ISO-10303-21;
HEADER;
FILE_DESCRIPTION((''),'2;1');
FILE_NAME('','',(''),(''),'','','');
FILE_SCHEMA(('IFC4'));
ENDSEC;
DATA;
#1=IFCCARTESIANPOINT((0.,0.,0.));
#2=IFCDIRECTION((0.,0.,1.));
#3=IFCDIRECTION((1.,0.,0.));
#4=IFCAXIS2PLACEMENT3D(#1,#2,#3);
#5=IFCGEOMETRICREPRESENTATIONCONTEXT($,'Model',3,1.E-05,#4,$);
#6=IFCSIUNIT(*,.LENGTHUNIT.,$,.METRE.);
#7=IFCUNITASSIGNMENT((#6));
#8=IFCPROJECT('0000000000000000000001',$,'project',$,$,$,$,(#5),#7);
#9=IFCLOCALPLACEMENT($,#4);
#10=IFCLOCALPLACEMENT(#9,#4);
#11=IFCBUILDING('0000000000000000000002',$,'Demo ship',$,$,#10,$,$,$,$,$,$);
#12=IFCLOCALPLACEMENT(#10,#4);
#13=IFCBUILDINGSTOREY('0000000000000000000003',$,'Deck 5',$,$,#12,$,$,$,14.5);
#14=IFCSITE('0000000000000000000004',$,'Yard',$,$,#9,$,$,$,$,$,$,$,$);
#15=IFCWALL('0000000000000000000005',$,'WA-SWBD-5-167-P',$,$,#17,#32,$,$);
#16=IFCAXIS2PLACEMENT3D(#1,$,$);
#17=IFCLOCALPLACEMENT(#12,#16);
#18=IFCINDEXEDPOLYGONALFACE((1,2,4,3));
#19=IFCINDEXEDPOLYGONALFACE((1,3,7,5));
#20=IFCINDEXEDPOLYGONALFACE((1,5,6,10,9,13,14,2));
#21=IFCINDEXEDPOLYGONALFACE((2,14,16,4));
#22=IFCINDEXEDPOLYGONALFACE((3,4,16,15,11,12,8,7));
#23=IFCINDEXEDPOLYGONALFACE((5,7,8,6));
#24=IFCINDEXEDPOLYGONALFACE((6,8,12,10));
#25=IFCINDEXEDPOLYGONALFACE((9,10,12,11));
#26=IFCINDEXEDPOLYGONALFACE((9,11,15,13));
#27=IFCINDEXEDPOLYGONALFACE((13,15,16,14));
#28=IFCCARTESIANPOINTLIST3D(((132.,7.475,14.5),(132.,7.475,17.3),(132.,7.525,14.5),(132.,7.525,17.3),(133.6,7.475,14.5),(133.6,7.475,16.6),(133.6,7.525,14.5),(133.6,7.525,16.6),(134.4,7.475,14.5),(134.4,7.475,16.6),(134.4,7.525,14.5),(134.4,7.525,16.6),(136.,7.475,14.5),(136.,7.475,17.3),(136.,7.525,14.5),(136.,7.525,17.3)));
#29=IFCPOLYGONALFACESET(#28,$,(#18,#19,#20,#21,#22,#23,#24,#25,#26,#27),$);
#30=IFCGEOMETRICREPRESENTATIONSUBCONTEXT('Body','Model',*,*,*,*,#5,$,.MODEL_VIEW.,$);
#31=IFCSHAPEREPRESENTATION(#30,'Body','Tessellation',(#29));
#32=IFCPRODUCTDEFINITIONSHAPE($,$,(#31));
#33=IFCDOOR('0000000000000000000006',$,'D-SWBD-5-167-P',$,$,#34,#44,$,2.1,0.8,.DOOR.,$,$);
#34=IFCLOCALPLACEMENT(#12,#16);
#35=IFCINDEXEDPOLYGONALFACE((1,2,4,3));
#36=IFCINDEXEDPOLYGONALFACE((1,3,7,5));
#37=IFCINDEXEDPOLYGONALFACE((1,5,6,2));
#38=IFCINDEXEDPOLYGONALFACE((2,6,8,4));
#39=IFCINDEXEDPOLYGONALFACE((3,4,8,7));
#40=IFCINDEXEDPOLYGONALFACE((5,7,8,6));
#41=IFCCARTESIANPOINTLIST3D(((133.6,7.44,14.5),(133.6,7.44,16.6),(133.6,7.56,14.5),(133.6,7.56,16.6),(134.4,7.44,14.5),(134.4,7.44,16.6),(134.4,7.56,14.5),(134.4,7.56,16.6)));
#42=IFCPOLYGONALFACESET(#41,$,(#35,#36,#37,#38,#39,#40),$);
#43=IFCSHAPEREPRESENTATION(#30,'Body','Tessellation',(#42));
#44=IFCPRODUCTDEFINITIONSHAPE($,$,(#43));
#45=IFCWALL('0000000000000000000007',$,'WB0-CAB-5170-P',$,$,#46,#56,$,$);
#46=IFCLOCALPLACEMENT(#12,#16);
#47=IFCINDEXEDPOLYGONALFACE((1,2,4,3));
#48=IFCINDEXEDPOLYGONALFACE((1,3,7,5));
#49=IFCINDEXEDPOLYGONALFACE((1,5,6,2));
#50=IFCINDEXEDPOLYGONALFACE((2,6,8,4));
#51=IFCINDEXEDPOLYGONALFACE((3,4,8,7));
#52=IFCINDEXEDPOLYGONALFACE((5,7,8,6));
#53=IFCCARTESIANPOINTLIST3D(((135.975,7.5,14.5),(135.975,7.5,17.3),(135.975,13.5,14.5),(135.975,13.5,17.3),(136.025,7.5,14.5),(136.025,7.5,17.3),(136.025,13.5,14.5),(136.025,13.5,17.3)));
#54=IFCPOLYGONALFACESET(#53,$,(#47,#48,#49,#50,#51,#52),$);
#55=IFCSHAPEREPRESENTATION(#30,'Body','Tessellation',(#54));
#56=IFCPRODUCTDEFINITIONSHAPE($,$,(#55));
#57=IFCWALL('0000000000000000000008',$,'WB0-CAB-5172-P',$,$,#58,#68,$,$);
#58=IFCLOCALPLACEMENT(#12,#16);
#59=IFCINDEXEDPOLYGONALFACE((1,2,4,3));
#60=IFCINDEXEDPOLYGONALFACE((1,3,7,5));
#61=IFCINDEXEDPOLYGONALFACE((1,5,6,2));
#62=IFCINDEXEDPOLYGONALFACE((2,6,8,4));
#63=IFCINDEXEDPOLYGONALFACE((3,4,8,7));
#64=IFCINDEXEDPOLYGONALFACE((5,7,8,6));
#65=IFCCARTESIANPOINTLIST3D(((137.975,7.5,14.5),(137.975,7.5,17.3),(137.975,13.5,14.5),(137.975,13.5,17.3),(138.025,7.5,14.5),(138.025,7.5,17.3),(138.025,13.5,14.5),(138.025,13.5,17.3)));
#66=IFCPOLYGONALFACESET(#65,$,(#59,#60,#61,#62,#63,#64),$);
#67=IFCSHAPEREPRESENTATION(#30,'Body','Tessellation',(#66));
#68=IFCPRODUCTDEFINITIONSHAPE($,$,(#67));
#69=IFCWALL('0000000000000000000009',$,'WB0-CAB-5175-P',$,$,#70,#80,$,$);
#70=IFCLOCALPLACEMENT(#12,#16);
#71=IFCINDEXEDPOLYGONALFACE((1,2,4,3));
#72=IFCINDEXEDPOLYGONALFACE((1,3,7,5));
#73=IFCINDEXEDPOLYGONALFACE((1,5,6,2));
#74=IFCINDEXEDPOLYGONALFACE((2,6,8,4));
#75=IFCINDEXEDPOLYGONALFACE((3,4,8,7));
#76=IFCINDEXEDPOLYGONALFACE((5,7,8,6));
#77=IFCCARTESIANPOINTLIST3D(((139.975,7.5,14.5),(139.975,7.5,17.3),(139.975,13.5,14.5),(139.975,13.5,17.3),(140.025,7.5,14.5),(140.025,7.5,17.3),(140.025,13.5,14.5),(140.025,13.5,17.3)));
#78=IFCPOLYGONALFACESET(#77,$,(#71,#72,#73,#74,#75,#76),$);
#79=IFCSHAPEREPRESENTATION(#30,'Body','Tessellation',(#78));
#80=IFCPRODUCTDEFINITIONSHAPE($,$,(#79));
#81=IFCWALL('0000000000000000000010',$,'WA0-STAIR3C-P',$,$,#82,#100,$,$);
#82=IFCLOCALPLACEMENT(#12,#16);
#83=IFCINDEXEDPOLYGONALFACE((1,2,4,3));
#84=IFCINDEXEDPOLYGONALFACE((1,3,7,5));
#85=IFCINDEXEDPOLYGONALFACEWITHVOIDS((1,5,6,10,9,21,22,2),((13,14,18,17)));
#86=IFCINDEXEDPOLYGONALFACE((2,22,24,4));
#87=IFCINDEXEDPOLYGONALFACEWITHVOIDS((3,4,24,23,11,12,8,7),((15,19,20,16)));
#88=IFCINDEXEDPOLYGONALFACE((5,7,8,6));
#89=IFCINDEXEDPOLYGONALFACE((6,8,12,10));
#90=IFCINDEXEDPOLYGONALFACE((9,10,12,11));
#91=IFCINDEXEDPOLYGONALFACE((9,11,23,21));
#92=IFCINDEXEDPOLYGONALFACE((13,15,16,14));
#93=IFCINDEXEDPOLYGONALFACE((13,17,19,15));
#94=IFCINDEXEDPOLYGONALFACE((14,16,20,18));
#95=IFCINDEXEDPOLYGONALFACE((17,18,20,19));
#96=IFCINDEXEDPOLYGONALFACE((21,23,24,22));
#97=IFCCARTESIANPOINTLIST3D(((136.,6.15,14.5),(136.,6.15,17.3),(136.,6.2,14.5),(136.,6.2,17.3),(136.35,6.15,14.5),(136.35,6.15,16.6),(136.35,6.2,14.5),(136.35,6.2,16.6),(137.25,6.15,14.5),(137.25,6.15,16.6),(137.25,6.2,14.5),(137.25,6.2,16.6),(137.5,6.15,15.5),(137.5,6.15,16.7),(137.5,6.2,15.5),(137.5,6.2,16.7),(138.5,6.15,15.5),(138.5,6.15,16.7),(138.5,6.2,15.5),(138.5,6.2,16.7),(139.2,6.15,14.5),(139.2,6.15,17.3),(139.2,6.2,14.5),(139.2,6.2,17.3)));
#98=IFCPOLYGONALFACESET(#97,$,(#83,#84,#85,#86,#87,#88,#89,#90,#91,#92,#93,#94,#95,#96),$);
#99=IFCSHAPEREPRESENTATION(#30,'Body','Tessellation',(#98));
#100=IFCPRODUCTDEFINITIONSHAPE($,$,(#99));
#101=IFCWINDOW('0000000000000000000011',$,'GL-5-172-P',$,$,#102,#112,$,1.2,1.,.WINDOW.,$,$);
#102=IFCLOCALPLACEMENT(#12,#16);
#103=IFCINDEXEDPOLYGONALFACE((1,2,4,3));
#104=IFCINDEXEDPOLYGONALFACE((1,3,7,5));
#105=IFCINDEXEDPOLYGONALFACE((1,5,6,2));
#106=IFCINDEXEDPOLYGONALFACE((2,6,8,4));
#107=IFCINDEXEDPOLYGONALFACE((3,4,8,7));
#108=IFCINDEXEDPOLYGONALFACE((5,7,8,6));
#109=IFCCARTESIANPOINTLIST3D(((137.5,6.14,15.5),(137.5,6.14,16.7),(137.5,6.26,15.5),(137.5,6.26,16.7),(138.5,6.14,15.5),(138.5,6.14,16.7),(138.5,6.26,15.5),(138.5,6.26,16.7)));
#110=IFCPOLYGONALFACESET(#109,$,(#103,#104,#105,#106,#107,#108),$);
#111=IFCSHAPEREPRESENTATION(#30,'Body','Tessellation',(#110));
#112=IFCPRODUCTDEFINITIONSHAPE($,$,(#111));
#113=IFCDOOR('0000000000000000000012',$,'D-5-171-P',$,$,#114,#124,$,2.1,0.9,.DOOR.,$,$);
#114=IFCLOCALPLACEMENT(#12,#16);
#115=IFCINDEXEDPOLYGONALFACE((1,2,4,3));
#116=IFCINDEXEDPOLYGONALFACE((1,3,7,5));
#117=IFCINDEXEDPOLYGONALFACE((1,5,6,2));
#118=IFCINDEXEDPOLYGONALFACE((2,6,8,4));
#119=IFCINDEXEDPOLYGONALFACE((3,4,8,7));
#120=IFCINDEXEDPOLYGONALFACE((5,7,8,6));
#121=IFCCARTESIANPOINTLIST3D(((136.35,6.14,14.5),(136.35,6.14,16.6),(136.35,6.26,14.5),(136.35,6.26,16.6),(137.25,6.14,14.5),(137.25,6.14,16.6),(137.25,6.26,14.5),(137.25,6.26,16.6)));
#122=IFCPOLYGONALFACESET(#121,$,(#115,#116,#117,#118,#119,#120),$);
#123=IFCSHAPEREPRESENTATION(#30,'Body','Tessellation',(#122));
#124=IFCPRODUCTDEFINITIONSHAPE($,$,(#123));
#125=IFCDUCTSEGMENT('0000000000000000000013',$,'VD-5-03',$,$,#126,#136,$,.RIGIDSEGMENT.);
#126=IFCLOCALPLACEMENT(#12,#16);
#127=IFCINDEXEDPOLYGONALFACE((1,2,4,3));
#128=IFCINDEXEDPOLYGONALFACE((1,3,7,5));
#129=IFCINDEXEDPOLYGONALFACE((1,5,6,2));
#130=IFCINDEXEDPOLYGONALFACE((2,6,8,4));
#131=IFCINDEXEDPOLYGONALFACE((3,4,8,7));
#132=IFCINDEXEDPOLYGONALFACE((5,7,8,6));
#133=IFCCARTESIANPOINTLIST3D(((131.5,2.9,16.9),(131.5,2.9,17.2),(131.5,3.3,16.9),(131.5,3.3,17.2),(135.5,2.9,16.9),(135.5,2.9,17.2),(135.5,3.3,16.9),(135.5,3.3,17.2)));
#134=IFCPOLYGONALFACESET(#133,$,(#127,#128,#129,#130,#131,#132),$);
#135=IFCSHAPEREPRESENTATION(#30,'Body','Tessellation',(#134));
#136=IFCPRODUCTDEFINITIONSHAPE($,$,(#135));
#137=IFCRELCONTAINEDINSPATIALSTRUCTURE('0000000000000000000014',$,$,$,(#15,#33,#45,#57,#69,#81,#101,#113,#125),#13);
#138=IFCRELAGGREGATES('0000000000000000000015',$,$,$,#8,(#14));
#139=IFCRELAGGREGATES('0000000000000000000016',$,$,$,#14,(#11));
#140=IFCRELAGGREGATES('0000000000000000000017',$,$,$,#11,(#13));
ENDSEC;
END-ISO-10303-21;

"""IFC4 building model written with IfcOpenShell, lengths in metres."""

from ifc_helpers import new_model, si_unit, frame, frame_2d, origin, origin_with_axes, place, context, subcontext, project, spatial, rectangle, extrude, element, fill, save


model = new_model("IFC4")

# Units and contexts
model_context = context("Model", 3, precision=1e-05, world=origin_with_axes())
body_context = subcontext(model_context, "Body", "Model", "MODEL_VIEW")
ifc_project = project(units=[si_unit("LENGTHUNIT", "METRE")], contexts=[model_context])

# Site, building, storey
site_placement = place(None, origin_with_axes())
site = spatial("IfcSite", under=ifc_project, at=site_placement, Name="Yard")
building_placement = place(site_placement, origin_with_axes())
building = spatial("IfcBuilding", under=site, at=building_placement, Name="Demo ship")
storey_placement = place(building_placement, origin_with_axes())
storey = spatial("IfcBuildingStorey", under=building, at=storey_placement, Name="Deck 5", Elevation=14.5)

# Wall, opening, door
wall_1_placement = place(storey_placement, frame((132.0, 7.475, 14.5), z_axis=(0.0, 0.0, 1.0), x_axis=(1.0, 0.0, 0.0)))
wall_1 = element("IfcWall", 1, at=wall_1_placement, inside=storey, Name="WA-SWBD-5-167-P", context=body_context, shape_type="SweptSolid", body=[
    extrude(rectangle(XDim=4.0, YDim=0.05, at=frame_2d((2.0, 0.025))), origin(), (0.0, 0.0, 1.0), 2.8),
])
opening_1_placement = place(None, frame((133.6, 7.44, 14.5), z_axis=(0.0, 0.0, 1.0), x_axis=(1.0, 0.0, 0.0)))
opening_1 = element("IfcOpeningElement", 2, at=opening_1_placement, cuts=wall_1, context=body_context, shape_type="SweptSolid", body=[
    extrude(rectangle(XDim=0.8, YDim=0.12, at=frame_2d((0.4, 0.06))), origin(), (0.0, 0.0, 1.0), 2.1),
])
door_1_placement = place(storey_placement, frame((133.6, 7.44, 14.5), z_axis=(0.0, 0.0, 1.0), x_axis=(1.0, 0.0, 0.0)))
door_1 = element("IfcDoor", 3, at=door_1_placement, inside=storey, Name="D-SWBD-5-167-P", OverallHeight=2.1, OverallWidth=0.8, PredefinedType="DOOR", context=body_context, shape_type="SweptSolid", body=[
    extrude(rectangle(XDim=0.8, YDim=0.12, at=frame_2d((0.4, 0.06))), origin(), (0.0, 0.0, 1.0), 2.1),
])
fill(opening_1, door_1)

# Walls
for number, where, z_axis, x_axis, name in (
    (4, (135.975, 7.5, 14.5), (0.0, 0.0, 1.0), (1.0, 0.0, 0.0), "WB0-CAB-5170-P"),
    (5, (137.975, 7.5, 14.5), (0.0, 0.0, 1.0), (1.0, 0.0, 0.0), "WB0-CAB-5172-P"),
    (6, (139.975, 7.5, 14.5), (0.0, 0.0, 1.0), (1.0, 0.0, 0.0), "WB0-CAB-5175-P"),
):
    element("IfcWall", number, at=place(storey_placement, frame(where, z_axis=z_axis, x_axis=x_axis)), inside=storey, Name=name, context=body_context, shape_type="SweptSolid", body=[
        extrude(rectangle(XDim=0.05, YDim=6.0, at=frame_2d((0.025, 3.0))), origin(), (0.0, 0.0, 1.0), 2.8),
    ])

# Wall, openings, window, door
wall_2_placement = place(storey_placement, frame((136.0, 6.15, 14.5), z_axis=(0.0, 0.0, 1.0), x_axis=(1.0, 0.0, 0.0)))
wall_2 = element("IfcWall", 7, at=wall_2_placement, inside=storey, Name="WA0-STAIR3C-P", context=body_context, shape_type="SweptSolid", body=[
    extrude(rectangle(XDim=3.2, YDim=0.05, at=frame_2d((1.6, 0.025))), origin(), (0.0, 0.0, 1.0), 2.8),
])
opening_2_placement = place(None, frame((137.5, 6.14, 15.5), z_axis=(0.0, 0.0, 1.0), x_axis=(1.0, 0.0, 0.0)))
opening_2 = element("IfcOpeningElement", 8, at=opening_2_placement, cuts=wall_2, context=body_context, shape_type="SweptSolid", body=[
    extrude(rectangle(XDim=1.0, YDim=0.12, at=frame_2d((0.5, 0.06))), origin(), (0.0, 0.0, 1.0), 1.2),
])
opening_3_placement = place(None, frame((136.35, 6.14, 14.5), z_axis=(0.0, 0.0, 1.0), x_axis=(1.0, 0.0, 0.0)))
opening_3 = element("IfcOpeningElement", 9, at=opening_3_placement, cuts=wall_2, context=body_context, shape_type="SweptSolid", body=[
    extrude(rectangle(XDim=0.9, YDim=0.12, at=frame_2d((0.45, 0.06))), origin(), (0.0, 0.0, 1.0), 2.1),
])
window_placement = place(storey_placement, frame((137.5, 6.14, 15.5), z_axis=(0.0, 0.0, 1.0), x_axis=(1.0, 0.0, 0.0)))
window = element("IfcWindow", 10, at=window_placement, inside=storey, Name="GL-5-172-P", OverallHeight=1.2, OverallWidth=1.0, PredefinedType="WINDOW", context=body_context, shape_type="SweptSolid", body=[
    extrude(rectangle(XDim=1.0, YDim=0.12, at=frame_2d((0.5, 0.06))), origin(), (0.0, 0.0, 1.0), 1.2),
])
fill(opening_2, window)
door_2_placement = place(storey_placement, frame((136.35, 6.14, 14.5), z_axis=(0.0, 0.0, 1.0), x_axis=(1.0, 0.0, 0.0)))
door_2 = element("IfcDoor", 11, at=door_2_placement, inside=storey, Name="D-5-171-P", OverallHeight=2.1, OverallWidth=0.9, PredefinedType="DOOR", context=body_context, shape_type="SweptSolid", body=[
    extrude(rectangle(XDim=0.9, YDim=0.12, at=frame_2d((0.45, 0.06))), origin(), (0.0, 0.0, 1.0), 2.1),
])
fill(opening_3, door_2)

# Duct segment
duct_segment_placement = place(storey_placement, frame((131.5, 2.9, 16.9), z_axis=(0.0, 0.0, 1.0), x_axis=(1.0, 0.0, 0.0)))
element("IfcDuctSegment", 12, at=duct_segment_placement, inside=storey, Name="VD-5-03", PredefinedType="RIGIDSEGMENT", context=body_context, shape_type="SweptSolid", body=[
    extrude(rectangle(XDim=4.0, YDim=0.4, at=frame_2d((2.0, 0.2))), origin(), (0.0, 0.0, 1.0), 0.3),
])

save(model, "model.ifc")
